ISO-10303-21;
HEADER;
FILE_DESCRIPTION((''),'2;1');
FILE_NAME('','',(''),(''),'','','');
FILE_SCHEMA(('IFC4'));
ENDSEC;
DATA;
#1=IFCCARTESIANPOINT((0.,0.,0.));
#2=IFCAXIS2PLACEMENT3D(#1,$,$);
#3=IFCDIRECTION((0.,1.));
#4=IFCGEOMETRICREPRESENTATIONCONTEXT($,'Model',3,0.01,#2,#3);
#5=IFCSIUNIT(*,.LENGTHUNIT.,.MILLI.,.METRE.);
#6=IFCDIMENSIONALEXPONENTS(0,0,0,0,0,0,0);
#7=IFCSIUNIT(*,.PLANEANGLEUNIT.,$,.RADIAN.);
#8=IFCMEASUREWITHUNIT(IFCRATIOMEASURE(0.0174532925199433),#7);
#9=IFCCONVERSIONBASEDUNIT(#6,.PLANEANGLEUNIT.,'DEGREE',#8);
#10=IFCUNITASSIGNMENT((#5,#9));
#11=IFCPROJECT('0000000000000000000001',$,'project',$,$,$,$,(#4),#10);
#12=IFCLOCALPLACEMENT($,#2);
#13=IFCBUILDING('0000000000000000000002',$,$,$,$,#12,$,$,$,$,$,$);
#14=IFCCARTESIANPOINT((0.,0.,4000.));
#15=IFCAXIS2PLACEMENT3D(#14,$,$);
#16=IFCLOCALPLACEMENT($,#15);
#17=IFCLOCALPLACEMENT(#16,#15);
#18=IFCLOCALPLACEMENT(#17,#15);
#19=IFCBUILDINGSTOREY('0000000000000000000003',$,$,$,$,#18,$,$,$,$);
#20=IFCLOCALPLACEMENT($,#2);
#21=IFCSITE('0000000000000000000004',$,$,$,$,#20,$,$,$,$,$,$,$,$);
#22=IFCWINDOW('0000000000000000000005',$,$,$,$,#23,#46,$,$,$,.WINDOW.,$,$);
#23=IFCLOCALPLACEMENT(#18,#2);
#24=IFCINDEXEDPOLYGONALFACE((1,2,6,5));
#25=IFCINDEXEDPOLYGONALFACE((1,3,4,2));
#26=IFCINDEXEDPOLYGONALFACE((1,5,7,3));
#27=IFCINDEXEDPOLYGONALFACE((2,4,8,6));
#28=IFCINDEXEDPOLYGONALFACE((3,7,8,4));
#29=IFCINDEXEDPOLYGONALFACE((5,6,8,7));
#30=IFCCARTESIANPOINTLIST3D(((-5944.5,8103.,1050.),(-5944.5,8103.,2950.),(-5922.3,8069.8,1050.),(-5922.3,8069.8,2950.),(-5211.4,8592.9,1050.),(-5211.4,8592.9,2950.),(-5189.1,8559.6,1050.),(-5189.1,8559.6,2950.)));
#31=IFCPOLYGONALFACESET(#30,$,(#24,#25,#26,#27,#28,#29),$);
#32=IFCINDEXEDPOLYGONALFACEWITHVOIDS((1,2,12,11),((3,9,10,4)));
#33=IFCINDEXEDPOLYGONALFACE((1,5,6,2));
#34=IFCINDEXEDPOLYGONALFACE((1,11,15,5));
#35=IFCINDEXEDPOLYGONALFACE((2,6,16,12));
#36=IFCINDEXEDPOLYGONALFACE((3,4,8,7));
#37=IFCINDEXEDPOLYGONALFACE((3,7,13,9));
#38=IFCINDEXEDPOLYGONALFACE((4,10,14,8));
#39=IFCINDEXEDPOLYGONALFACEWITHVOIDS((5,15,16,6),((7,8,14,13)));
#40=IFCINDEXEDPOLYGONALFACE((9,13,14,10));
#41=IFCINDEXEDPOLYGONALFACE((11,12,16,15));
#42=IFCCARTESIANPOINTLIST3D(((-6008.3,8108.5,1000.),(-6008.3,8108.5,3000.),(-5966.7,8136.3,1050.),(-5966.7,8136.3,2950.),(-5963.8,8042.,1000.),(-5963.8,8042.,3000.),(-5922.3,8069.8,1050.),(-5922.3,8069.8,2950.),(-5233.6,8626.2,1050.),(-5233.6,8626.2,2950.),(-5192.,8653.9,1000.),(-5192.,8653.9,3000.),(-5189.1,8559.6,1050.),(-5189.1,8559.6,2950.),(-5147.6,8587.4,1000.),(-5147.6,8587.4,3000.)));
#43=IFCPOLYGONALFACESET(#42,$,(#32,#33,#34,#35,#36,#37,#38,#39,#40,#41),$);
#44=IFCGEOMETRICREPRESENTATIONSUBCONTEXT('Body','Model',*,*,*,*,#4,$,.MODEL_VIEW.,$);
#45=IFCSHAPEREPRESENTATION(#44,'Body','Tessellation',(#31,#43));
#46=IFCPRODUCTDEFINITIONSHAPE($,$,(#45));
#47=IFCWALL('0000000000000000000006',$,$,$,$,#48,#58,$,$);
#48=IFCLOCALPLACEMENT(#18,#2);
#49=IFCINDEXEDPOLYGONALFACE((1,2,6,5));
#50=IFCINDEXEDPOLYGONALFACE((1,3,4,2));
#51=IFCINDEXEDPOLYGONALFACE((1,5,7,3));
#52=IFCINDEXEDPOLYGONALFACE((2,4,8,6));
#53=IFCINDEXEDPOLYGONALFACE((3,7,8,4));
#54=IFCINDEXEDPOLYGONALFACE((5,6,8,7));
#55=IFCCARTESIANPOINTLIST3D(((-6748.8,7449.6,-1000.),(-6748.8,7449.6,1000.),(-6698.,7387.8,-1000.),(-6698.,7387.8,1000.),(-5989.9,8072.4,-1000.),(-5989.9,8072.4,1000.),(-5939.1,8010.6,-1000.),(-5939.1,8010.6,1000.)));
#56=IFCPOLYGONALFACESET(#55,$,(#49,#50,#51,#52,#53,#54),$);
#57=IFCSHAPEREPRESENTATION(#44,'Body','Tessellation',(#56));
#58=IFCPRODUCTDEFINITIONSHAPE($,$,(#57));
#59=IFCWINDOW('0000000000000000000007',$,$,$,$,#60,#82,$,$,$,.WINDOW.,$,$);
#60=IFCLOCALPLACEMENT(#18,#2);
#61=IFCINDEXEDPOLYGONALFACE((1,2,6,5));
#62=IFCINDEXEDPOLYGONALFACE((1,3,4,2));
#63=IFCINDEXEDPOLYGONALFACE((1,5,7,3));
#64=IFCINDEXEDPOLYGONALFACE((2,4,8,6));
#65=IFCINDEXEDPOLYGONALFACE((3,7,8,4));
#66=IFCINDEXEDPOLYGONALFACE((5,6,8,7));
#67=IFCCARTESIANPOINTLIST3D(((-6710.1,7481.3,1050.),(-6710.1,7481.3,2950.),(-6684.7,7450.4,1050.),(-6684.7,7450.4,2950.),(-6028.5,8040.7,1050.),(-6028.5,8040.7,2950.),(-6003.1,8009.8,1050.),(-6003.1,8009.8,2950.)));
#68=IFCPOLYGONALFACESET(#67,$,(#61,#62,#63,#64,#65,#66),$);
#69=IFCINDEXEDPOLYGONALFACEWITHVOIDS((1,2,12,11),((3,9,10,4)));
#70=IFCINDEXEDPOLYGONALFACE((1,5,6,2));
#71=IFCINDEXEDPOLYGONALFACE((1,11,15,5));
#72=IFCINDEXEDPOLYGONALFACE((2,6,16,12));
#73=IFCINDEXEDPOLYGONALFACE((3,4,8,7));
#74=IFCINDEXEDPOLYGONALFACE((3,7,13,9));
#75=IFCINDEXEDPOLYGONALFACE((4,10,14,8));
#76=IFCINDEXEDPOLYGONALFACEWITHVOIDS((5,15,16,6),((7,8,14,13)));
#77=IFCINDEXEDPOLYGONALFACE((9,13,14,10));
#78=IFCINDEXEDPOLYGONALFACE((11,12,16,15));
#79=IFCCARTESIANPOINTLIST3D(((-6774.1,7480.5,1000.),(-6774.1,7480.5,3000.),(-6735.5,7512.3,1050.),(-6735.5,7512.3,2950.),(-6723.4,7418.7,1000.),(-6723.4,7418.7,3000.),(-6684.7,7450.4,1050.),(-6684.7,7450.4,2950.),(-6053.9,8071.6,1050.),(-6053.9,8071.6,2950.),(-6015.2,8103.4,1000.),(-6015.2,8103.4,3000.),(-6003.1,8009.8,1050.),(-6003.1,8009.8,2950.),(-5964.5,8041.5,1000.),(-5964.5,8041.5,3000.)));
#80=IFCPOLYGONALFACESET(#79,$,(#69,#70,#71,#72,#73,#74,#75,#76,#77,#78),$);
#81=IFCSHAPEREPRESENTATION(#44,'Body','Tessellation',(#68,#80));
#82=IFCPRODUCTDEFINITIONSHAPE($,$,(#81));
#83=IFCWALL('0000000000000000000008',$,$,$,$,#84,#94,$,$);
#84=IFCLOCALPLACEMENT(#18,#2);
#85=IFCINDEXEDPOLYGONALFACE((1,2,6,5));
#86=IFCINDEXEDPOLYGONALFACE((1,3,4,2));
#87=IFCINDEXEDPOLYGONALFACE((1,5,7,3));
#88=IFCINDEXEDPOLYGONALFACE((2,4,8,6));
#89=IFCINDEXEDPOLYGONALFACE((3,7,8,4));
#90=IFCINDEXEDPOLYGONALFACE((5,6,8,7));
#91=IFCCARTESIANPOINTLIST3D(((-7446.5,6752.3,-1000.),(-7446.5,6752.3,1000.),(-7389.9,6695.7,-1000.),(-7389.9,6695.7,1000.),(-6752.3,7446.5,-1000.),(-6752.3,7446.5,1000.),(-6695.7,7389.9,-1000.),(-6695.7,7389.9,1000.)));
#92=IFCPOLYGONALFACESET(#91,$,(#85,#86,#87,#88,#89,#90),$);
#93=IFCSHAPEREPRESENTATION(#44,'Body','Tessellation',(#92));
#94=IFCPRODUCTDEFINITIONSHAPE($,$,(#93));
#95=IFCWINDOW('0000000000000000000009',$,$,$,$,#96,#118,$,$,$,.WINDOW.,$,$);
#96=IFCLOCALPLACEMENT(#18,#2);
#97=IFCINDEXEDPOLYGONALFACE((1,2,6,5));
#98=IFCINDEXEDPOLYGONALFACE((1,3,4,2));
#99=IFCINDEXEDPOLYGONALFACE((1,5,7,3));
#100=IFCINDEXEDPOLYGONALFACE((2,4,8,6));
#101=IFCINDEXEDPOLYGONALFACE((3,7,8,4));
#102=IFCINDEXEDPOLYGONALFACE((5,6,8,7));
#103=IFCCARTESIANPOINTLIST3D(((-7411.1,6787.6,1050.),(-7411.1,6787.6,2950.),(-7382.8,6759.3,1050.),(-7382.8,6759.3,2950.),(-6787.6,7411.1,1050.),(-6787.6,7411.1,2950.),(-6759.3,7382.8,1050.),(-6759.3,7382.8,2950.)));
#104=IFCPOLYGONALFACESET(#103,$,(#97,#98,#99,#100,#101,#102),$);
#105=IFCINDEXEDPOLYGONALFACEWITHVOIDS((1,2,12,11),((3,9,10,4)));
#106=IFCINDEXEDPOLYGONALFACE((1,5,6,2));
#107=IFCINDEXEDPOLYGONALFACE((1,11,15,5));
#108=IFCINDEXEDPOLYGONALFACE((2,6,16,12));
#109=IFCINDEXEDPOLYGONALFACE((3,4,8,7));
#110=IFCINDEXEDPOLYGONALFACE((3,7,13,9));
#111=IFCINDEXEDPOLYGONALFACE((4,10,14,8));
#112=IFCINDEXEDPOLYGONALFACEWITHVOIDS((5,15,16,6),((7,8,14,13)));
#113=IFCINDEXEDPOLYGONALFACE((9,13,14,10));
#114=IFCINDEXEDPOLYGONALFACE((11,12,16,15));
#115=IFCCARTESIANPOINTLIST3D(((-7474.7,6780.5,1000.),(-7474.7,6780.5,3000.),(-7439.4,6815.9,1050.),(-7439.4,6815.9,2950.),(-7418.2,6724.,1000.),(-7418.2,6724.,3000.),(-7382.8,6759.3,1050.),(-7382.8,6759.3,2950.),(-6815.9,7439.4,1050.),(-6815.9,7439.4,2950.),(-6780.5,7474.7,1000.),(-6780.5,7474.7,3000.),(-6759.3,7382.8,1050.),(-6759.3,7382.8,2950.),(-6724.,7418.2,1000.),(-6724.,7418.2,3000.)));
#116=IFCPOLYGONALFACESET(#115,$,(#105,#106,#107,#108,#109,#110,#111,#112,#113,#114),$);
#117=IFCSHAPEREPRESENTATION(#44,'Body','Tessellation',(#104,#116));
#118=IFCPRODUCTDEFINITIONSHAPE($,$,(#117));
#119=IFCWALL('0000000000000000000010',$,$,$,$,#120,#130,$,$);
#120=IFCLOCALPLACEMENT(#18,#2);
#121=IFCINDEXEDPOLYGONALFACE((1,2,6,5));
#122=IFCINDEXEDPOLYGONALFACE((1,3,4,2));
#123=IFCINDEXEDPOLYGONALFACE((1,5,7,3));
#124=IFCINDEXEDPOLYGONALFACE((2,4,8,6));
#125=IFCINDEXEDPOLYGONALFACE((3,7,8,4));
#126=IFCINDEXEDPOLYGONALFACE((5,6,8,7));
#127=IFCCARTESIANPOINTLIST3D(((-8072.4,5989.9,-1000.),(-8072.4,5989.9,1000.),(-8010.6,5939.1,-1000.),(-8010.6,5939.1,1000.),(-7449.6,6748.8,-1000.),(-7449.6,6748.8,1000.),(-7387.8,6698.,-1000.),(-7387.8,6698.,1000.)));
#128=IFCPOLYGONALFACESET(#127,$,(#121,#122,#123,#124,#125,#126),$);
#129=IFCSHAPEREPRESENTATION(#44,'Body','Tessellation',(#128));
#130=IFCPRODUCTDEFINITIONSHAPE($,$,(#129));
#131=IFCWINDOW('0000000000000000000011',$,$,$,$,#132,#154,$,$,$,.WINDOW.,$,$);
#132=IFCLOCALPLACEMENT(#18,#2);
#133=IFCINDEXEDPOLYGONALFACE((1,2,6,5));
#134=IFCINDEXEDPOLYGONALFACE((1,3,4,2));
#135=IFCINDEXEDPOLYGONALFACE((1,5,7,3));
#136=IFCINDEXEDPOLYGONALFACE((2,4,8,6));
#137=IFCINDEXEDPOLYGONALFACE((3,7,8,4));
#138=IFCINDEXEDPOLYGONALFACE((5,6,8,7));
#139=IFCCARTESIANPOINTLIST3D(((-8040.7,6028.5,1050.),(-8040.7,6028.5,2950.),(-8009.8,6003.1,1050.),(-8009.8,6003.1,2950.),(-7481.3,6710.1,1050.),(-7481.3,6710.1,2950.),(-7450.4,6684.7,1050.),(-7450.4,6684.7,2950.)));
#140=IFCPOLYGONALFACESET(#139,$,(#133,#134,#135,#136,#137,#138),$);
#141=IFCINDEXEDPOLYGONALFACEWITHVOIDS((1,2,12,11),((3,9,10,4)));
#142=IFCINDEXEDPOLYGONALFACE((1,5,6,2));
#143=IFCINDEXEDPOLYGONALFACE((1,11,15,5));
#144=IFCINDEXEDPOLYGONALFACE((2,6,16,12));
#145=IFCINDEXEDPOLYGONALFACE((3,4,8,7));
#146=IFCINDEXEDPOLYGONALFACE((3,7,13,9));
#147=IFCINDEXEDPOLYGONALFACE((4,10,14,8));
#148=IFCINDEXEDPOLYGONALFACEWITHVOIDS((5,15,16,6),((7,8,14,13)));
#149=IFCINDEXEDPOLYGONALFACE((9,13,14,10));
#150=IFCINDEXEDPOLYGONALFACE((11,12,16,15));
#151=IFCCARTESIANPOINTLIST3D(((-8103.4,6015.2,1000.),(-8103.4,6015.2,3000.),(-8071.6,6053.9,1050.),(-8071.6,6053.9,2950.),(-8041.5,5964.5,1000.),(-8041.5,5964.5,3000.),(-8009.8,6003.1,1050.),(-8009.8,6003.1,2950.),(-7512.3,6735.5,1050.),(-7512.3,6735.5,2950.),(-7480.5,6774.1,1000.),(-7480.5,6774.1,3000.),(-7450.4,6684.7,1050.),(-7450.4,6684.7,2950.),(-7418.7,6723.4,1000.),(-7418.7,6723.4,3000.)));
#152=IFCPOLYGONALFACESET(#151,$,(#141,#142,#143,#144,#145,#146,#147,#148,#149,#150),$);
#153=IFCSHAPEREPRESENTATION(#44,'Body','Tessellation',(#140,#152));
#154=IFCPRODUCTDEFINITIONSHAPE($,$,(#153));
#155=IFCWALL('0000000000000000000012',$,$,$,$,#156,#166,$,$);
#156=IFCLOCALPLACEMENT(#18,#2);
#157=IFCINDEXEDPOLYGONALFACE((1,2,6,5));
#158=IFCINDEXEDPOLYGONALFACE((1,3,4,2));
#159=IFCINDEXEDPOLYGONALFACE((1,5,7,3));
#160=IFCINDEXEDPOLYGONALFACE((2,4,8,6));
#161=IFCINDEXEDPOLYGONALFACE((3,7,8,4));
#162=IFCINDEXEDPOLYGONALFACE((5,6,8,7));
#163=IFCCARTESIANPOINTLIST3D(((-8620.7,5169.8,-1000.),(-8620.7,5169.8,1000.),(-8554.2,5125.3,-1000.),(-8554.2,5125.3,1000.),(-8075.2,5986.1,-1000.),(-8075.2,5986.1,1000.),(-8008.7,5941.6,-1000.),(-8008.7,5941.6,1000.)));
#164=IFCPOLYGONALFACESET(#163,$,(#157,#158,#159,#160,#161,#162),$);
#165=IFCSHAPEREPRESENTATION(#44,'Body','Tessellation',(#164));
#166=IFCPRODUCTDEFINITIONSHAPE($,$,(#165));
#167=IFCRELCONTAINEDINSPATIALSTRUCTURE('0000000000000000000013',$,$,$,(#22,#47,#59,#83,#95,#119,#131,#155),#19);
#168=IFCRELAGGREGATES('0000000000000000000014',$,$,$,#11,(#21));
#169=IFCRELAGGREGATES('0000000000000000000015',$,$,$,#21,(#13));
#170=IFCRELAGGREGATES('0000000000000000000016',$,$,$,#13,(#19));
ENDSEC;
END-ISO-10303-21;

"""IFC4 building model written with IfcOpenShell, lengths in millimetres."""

from ifc_helpers import new_model, entity, si_unit, converted_unit, direction, frame, origin, origin_2d, place, context, subcontext, project, spatial, rectangle, extrude, element, save


model = new_model("IFC4")

# Units and contexts
model_context = context("Model", 3, precision=0.01, world=origin(), true_north=direction((0.0, 1.0)))
body_context = subcontext(model_context, "Body", "Model", "MODEL_VIEW")
ifc_project = project(units=[si_unit("LENGTHUNIT", "METRE", prefix="MILLI"), converted_unit("PLANEANGLEUNIT", "DEGREE", entity("IfcRatioMeasure", 0.0174532925199433), si_unit("PLANEANGLEUNIT", "RADIAN"), dimensions=[0, 0, 0, 0, 0, 0, 0])], contexts=[model_context])

# Site, building, storey
site_placement = place(None, origin())
site = spatial("IfcSite", under=ifc_project, at=site_placement)
building_placement = place(None, origin())
building = spatial("IfcBuilding", under=site, at=building_placement)
placement_1 = place(None, frame((0.0, 0.0, 4000.0)))
placement_2 = place(placement_1, frame((0.0, 0.0, 4000.0)))
storey_placement = place(placement_2, frame((0.0, 0.0, 4000.0)))
storey = spatial("IfcBuildingStorey", under=building, at=storey_placement)

# Shared definitions
cartesian_point_1 = entity("IfcCartesianPoint", [-440.9, -950.0])
shared_polyline = entity("IfcPolyline", [cartesian_point_1, entity("IfcCartesianPoint", [-440.9, 950.0]), entity("IfcCartesianPoint", [-440.9, 950.0]), entity("IfcCartesianPoint", [440.9, 950.0]), entity("IfcCartesianPoint", [440.9, 950.0]), entity("IfcCartesianPoint", [440.9, -950.0]), entity("IfcCartesianPoint", [440.9, -950.0]), entity("IfcCartesianPoint", [-440.9, -950.0]), cartesian_point_1])

# Window
window_1_placement = place(storey_placement, frame((-5555.7, 8314.7, 2000.0), z_axis=(0.0, 0.0, 1.0), x_axis=(-8314.696534, -5555.701715, 0.0)))
cartesian_point_2 = entity("IfcCartesianPoint", [-490.9, -1000.0])
element("IfcWindow", 1, at=window_1_placement, inside=storey, PredefinedType="WINDOW", context=body_context, shape_type="SweptSolid", body=[
    entity("IfcExtrudedAreaSolid", entity("IfcArbitraryClosedProfileDef", "AREA", None, shared_polyline), entity("IfcAxis2Placement3D", entity("IfcCartesianPoint", [0.0, 0.0, 0.0]), entity("IfcDirection", [0.0, -1.0, 0.0]), entity("IfcDirection", [1.0, 0.0, 0.0])), entity("IfcDirection", [0.0, 0.0, 1.0]), 40.0),
    entity("IfcExtrudedAreaSolid", entity("IfcArbitraryProfileDefWithVoids", "AREA", None, entity("IfcPolyline", [cartesian_point_2, entity("IfcCartesianPoint", [-490.9, 1000.0]), entity("IfcCartesianPoint", [-490.9, 1000.0]), entity("IfcCartesianPoint", [490.9, 1000.0]), entity("IfcCartesianPoint", [490.9, 1000.0]), entity("IfcCartesianPoint", [490.9, -1000.0]), entity("IfcCartesianPoint", [490.9, -1000.0]), entity("IfcCartesianPoint", [-490.9, -1000.0]), cartesian_point_2]), [shared_polyline]), entity("IfcAxis2Placement3D", entity("IfcCartesianPoint", [0.0, 0.0, 0.0]), entity("IfcDirection", [0.0, -1.0, 0.0]), entity("IfcDirection", [1.0, 0.0, 0.0])), entity("IfcDirection", [0.0, 0.0, 1.0]), 80.0),
])

# Wall
wall_1_placement = place(storey_placement, frame((-6343.9, 7730.1, -1000.0), z_axis=(0.0, 0.0, 1.0), x_axis=(-7730.104749, -6343.932579, 0.0)))
element("IfcWall", 2, at=wall_1_placement, inside=storey, context=body_context, shape_type="SweptSolid", body=[
    extrude(rectangle(XDim=981.7, YDim=80.0, at=origin_2d()), origin(), (0.0, 0.0, 1.0), 2000.0),
])

# Window
window_2_placement = place(storey_placement, frame((-6343.9, 7730.1, 2000.0), z_axis=(0.0, 0.0, 1.0), x_axis=(-7730.104749, -6343.932579, 0.0)))
cartesian_point_3 = entity("IfcCartesianPoint", [-490.9, -1000.0])
element("IfcWindow", 3, at=window_2_placement, inside=storey, PredefinedType="WINDOW", context=body_context, shape_type="SweptSolid", body=[
    entity("IfcExtrudedAreaSolid", entity("IfcArbitraryClosedProfileDef", "AREA", None, shared_polyline), entity("IfcAxis2Placement3D", entity("IfcCartesianPoint", [0.0, 0.0, 0.0]), entity("IfcDirection", [0.0, -1.0, 0.0]), entity("IfcDirection", [1.0, 0.0, 0.0])), entity("IfcDirection", [0.0, 0.0, 1.0]), 40.0),
    entity("IfcExtrudedAreaSolid", entity("IfcArbitraryProfileDefWithVoids", "AREA", None, entity("IfcPolyline", [cartesian_point_3, entity("IfcCartesianPoint", [-490.9, 1000.0]), entity("IfcCartesianPoint", [-490.9, 1000.0]), entity("IfcCartesianPoint", [490.9, 1000.0]), entity("IfcCartesianPoint", [490.9, 1000.0]), entity("IfcCartesianPoint", [490.9, -1000.0]), entity("IfcCartesianPoint", [490.9, -1000.0]), entity("IfcCartesianPoint", [-490.9, -1000.0]), cartesian_point_3]), [shared_polyline]), entity("IfcAxis2Placement3D", entity("IfcCartesianPoint", [0.0, 0.0, 0.0]), entity("IfcDirection", [0.0, -1.0, 0.0]), entity("IfcDirection", [1.0, 0.0, 0.0])), entity("IfcDirection", [0.0, 0.0, 1.0]), 80.0),
])

# Wall
wall_2_placement = place(storey_placement, frame((-7071.1, 7071.1, -1000.0), z_axis=(0.0, 0.0, 1.0), x_axis=(-7071.06777, -7071.067854, 0.0)))
element("IfcWall", 4, at=wall_2_placement, inside=storey, context=body_context, shape_type="SweptSolid", body=[
    extrude(rectangle(XDim=981.7, YDim=80.0, at=origin_2d()), origin(), (0.0, 0.0, 1.0), 2000.0),
])

# Window
window_3_placement = place(storey_placement, frame((-7071.1, 7071.1, 2000.0), z_axis=(0.0, 0.0, 1.0), x_axis=(-7071.06777, -7071.067854, 0.0)))
cartesian_point_4 = entity("IfcCartesianPoint", [-490.9, -1000.0])
element("IfcWindow", 5, at=window_3_placement, inside=storey, PredefinedType="WINDOW", context=body_context, shape_type="SweptSolid", body=[
    entity("IfcExtrudedAreaSolid", entity("IfcArbitraryClosedProfileDef", "AREA", None, shared_polyline), entity("IfcAxis2Placement3D", entity("IfcCartesianPoint", [0.0, 0.0, 0.0]), entity("IfcDirection", [0.0, -1.0, 0.0]), entity("IfcDirection", [1.0, 0.0, 0.0])), entity("IfcDirection", [0.0, 0.0, 1.0]), 40.0),
    entity("IfcExtrudedAreaSolid", entity("IfcArbitraryProfileDefWithVoids", "AREA", None, entity("IfcPolyline", [cartesian_point_4, entity("IfcCartesianPoint", [-490.9, 1000.0]), entity("IfcCartesianPoint", [-490.9, 1000.0]), entity("IfcCartesianPoint", [490.9, 1000.0]), entity("IfcCartesianPoint", [490.9, 1000.0]), entity("IfcCartesianPoint", [490.9, -1000.0]), entity("IfcCartesianPoint", [490.9, -1000.0]), entity("IfcCartesianPoint", [-490.9, -1000.0]), cartesian_point_4]), [shared_polyline]), entity("IfcAxis2Placement3D", entity("IfcCartesianPoint", [0.0, 0.0, 0.0]), entity("IfcDirection", [0.0, -1.0, 0.0]), entity("IfcDirection", [1.0, 0.0, 0.0])), entity("IfcDirection", [0.0, 0.0, 1.0]), 80.0),
])

# Wall
wall_3_placement = place(storey_placement, frame((-7730.1, 6343.9, -1000.0), z_axis=(0.0, 0.0, 1.0), x_axis=(-6343.932486, -7730.104825, 0.0)))
element("IfcWall", 6, at=wall_3_placement, inside=storey, context=body_context, shape_type="SweptSolid", body=[
    extrude(rectangle(XDim=981.7, YDim=80.0, at=origin_2d()), origin(), (0.0, 0.0, 1.0), 2000.0),
])

# Window
window_4_placement = place(storey_placement, frame((-7730.1, 6343.9, 2000.0), z_axis=(0.0, 0.0, 1.0), x_axis=(-6343.932486, -7730.104825, 0.0)))
cartesian_point_5 = entity("IfcCartesianPoint", [-490.9, -1000.0])
element("IfcWindow", 7, at=window_4_placement, inside=storey, PredefinedType="WINDOW", context=body_context, shape_type="SweptSolid", body=[
    entity("IfcExtrudedAreaSolid", entity("IfcArbitraryClosedProfileDef", "AREA", None, shared_polyline), entity("IfcAxis2Placement3D", entity("IfcCartesianPoint", [0.0, 0.0, 0.0]), entity("IfcDirection", [0.0, -1.0, 0.0]), entity("IfcDirection", [1.0, 0.0, 0.0])), entity("IfcDirection", [0.0, 0.0, 1.0]), 40.0),
    entity("IfcExtrudedAreaSolid", entity("IfcArbitraryProfileDefWithVoids", "AREA", None, entity("IfcPolyline", [cartesian_point_5, entity("IfcCartesianPoint", [-490.9, 1000.0]), entity("IfcCartesianPoint", [-490.9, 1000.0]), entity("IfcCartesianPoint", [490.9, 1000.0]), entity("IfcCartesianPoint", [490.9, 1000.0]), entity("IfcCartesianPoint", [490.9, -1000.0]), entity("IfcCartesianPoint", [490.9, -1000.0]), entity("IfcCartesianPoint", [-490.9, -1000.0]), cartesian_point_5]), [shared_polyline]), entity("IfcAxis2Placement3D", entity("IfcCartesianPoint", [0.0, 0.0, 0.0]), entity("IfcDirection", [0.0, -1.0, 0.0]), entity("IfcDirection", [1.0, 0.0, 0.0])), entity("IfcDirection", [0.0, 0.0, 1.0]), 80.0),
])

# Wall
wall_4_placement = place(storey_placement, frame((-8314.7, 5555.7, -1000.0), z_axis=(0.0, 0.0, 1.0), x_axis=(-5555.701616, -8314.6966, 0.0)))
element("IfcWall", 8, at=wall_4_placement, inside=storey, context=body_context, shape_type="SweptSolid", body=[
    extrude(rectangle(XDim=981.7, YDim=80.0, at=origin_2d()), origin(), (0.0, 0.0, 1.0), 2000.0),
])

save(model, "model.ifc")
